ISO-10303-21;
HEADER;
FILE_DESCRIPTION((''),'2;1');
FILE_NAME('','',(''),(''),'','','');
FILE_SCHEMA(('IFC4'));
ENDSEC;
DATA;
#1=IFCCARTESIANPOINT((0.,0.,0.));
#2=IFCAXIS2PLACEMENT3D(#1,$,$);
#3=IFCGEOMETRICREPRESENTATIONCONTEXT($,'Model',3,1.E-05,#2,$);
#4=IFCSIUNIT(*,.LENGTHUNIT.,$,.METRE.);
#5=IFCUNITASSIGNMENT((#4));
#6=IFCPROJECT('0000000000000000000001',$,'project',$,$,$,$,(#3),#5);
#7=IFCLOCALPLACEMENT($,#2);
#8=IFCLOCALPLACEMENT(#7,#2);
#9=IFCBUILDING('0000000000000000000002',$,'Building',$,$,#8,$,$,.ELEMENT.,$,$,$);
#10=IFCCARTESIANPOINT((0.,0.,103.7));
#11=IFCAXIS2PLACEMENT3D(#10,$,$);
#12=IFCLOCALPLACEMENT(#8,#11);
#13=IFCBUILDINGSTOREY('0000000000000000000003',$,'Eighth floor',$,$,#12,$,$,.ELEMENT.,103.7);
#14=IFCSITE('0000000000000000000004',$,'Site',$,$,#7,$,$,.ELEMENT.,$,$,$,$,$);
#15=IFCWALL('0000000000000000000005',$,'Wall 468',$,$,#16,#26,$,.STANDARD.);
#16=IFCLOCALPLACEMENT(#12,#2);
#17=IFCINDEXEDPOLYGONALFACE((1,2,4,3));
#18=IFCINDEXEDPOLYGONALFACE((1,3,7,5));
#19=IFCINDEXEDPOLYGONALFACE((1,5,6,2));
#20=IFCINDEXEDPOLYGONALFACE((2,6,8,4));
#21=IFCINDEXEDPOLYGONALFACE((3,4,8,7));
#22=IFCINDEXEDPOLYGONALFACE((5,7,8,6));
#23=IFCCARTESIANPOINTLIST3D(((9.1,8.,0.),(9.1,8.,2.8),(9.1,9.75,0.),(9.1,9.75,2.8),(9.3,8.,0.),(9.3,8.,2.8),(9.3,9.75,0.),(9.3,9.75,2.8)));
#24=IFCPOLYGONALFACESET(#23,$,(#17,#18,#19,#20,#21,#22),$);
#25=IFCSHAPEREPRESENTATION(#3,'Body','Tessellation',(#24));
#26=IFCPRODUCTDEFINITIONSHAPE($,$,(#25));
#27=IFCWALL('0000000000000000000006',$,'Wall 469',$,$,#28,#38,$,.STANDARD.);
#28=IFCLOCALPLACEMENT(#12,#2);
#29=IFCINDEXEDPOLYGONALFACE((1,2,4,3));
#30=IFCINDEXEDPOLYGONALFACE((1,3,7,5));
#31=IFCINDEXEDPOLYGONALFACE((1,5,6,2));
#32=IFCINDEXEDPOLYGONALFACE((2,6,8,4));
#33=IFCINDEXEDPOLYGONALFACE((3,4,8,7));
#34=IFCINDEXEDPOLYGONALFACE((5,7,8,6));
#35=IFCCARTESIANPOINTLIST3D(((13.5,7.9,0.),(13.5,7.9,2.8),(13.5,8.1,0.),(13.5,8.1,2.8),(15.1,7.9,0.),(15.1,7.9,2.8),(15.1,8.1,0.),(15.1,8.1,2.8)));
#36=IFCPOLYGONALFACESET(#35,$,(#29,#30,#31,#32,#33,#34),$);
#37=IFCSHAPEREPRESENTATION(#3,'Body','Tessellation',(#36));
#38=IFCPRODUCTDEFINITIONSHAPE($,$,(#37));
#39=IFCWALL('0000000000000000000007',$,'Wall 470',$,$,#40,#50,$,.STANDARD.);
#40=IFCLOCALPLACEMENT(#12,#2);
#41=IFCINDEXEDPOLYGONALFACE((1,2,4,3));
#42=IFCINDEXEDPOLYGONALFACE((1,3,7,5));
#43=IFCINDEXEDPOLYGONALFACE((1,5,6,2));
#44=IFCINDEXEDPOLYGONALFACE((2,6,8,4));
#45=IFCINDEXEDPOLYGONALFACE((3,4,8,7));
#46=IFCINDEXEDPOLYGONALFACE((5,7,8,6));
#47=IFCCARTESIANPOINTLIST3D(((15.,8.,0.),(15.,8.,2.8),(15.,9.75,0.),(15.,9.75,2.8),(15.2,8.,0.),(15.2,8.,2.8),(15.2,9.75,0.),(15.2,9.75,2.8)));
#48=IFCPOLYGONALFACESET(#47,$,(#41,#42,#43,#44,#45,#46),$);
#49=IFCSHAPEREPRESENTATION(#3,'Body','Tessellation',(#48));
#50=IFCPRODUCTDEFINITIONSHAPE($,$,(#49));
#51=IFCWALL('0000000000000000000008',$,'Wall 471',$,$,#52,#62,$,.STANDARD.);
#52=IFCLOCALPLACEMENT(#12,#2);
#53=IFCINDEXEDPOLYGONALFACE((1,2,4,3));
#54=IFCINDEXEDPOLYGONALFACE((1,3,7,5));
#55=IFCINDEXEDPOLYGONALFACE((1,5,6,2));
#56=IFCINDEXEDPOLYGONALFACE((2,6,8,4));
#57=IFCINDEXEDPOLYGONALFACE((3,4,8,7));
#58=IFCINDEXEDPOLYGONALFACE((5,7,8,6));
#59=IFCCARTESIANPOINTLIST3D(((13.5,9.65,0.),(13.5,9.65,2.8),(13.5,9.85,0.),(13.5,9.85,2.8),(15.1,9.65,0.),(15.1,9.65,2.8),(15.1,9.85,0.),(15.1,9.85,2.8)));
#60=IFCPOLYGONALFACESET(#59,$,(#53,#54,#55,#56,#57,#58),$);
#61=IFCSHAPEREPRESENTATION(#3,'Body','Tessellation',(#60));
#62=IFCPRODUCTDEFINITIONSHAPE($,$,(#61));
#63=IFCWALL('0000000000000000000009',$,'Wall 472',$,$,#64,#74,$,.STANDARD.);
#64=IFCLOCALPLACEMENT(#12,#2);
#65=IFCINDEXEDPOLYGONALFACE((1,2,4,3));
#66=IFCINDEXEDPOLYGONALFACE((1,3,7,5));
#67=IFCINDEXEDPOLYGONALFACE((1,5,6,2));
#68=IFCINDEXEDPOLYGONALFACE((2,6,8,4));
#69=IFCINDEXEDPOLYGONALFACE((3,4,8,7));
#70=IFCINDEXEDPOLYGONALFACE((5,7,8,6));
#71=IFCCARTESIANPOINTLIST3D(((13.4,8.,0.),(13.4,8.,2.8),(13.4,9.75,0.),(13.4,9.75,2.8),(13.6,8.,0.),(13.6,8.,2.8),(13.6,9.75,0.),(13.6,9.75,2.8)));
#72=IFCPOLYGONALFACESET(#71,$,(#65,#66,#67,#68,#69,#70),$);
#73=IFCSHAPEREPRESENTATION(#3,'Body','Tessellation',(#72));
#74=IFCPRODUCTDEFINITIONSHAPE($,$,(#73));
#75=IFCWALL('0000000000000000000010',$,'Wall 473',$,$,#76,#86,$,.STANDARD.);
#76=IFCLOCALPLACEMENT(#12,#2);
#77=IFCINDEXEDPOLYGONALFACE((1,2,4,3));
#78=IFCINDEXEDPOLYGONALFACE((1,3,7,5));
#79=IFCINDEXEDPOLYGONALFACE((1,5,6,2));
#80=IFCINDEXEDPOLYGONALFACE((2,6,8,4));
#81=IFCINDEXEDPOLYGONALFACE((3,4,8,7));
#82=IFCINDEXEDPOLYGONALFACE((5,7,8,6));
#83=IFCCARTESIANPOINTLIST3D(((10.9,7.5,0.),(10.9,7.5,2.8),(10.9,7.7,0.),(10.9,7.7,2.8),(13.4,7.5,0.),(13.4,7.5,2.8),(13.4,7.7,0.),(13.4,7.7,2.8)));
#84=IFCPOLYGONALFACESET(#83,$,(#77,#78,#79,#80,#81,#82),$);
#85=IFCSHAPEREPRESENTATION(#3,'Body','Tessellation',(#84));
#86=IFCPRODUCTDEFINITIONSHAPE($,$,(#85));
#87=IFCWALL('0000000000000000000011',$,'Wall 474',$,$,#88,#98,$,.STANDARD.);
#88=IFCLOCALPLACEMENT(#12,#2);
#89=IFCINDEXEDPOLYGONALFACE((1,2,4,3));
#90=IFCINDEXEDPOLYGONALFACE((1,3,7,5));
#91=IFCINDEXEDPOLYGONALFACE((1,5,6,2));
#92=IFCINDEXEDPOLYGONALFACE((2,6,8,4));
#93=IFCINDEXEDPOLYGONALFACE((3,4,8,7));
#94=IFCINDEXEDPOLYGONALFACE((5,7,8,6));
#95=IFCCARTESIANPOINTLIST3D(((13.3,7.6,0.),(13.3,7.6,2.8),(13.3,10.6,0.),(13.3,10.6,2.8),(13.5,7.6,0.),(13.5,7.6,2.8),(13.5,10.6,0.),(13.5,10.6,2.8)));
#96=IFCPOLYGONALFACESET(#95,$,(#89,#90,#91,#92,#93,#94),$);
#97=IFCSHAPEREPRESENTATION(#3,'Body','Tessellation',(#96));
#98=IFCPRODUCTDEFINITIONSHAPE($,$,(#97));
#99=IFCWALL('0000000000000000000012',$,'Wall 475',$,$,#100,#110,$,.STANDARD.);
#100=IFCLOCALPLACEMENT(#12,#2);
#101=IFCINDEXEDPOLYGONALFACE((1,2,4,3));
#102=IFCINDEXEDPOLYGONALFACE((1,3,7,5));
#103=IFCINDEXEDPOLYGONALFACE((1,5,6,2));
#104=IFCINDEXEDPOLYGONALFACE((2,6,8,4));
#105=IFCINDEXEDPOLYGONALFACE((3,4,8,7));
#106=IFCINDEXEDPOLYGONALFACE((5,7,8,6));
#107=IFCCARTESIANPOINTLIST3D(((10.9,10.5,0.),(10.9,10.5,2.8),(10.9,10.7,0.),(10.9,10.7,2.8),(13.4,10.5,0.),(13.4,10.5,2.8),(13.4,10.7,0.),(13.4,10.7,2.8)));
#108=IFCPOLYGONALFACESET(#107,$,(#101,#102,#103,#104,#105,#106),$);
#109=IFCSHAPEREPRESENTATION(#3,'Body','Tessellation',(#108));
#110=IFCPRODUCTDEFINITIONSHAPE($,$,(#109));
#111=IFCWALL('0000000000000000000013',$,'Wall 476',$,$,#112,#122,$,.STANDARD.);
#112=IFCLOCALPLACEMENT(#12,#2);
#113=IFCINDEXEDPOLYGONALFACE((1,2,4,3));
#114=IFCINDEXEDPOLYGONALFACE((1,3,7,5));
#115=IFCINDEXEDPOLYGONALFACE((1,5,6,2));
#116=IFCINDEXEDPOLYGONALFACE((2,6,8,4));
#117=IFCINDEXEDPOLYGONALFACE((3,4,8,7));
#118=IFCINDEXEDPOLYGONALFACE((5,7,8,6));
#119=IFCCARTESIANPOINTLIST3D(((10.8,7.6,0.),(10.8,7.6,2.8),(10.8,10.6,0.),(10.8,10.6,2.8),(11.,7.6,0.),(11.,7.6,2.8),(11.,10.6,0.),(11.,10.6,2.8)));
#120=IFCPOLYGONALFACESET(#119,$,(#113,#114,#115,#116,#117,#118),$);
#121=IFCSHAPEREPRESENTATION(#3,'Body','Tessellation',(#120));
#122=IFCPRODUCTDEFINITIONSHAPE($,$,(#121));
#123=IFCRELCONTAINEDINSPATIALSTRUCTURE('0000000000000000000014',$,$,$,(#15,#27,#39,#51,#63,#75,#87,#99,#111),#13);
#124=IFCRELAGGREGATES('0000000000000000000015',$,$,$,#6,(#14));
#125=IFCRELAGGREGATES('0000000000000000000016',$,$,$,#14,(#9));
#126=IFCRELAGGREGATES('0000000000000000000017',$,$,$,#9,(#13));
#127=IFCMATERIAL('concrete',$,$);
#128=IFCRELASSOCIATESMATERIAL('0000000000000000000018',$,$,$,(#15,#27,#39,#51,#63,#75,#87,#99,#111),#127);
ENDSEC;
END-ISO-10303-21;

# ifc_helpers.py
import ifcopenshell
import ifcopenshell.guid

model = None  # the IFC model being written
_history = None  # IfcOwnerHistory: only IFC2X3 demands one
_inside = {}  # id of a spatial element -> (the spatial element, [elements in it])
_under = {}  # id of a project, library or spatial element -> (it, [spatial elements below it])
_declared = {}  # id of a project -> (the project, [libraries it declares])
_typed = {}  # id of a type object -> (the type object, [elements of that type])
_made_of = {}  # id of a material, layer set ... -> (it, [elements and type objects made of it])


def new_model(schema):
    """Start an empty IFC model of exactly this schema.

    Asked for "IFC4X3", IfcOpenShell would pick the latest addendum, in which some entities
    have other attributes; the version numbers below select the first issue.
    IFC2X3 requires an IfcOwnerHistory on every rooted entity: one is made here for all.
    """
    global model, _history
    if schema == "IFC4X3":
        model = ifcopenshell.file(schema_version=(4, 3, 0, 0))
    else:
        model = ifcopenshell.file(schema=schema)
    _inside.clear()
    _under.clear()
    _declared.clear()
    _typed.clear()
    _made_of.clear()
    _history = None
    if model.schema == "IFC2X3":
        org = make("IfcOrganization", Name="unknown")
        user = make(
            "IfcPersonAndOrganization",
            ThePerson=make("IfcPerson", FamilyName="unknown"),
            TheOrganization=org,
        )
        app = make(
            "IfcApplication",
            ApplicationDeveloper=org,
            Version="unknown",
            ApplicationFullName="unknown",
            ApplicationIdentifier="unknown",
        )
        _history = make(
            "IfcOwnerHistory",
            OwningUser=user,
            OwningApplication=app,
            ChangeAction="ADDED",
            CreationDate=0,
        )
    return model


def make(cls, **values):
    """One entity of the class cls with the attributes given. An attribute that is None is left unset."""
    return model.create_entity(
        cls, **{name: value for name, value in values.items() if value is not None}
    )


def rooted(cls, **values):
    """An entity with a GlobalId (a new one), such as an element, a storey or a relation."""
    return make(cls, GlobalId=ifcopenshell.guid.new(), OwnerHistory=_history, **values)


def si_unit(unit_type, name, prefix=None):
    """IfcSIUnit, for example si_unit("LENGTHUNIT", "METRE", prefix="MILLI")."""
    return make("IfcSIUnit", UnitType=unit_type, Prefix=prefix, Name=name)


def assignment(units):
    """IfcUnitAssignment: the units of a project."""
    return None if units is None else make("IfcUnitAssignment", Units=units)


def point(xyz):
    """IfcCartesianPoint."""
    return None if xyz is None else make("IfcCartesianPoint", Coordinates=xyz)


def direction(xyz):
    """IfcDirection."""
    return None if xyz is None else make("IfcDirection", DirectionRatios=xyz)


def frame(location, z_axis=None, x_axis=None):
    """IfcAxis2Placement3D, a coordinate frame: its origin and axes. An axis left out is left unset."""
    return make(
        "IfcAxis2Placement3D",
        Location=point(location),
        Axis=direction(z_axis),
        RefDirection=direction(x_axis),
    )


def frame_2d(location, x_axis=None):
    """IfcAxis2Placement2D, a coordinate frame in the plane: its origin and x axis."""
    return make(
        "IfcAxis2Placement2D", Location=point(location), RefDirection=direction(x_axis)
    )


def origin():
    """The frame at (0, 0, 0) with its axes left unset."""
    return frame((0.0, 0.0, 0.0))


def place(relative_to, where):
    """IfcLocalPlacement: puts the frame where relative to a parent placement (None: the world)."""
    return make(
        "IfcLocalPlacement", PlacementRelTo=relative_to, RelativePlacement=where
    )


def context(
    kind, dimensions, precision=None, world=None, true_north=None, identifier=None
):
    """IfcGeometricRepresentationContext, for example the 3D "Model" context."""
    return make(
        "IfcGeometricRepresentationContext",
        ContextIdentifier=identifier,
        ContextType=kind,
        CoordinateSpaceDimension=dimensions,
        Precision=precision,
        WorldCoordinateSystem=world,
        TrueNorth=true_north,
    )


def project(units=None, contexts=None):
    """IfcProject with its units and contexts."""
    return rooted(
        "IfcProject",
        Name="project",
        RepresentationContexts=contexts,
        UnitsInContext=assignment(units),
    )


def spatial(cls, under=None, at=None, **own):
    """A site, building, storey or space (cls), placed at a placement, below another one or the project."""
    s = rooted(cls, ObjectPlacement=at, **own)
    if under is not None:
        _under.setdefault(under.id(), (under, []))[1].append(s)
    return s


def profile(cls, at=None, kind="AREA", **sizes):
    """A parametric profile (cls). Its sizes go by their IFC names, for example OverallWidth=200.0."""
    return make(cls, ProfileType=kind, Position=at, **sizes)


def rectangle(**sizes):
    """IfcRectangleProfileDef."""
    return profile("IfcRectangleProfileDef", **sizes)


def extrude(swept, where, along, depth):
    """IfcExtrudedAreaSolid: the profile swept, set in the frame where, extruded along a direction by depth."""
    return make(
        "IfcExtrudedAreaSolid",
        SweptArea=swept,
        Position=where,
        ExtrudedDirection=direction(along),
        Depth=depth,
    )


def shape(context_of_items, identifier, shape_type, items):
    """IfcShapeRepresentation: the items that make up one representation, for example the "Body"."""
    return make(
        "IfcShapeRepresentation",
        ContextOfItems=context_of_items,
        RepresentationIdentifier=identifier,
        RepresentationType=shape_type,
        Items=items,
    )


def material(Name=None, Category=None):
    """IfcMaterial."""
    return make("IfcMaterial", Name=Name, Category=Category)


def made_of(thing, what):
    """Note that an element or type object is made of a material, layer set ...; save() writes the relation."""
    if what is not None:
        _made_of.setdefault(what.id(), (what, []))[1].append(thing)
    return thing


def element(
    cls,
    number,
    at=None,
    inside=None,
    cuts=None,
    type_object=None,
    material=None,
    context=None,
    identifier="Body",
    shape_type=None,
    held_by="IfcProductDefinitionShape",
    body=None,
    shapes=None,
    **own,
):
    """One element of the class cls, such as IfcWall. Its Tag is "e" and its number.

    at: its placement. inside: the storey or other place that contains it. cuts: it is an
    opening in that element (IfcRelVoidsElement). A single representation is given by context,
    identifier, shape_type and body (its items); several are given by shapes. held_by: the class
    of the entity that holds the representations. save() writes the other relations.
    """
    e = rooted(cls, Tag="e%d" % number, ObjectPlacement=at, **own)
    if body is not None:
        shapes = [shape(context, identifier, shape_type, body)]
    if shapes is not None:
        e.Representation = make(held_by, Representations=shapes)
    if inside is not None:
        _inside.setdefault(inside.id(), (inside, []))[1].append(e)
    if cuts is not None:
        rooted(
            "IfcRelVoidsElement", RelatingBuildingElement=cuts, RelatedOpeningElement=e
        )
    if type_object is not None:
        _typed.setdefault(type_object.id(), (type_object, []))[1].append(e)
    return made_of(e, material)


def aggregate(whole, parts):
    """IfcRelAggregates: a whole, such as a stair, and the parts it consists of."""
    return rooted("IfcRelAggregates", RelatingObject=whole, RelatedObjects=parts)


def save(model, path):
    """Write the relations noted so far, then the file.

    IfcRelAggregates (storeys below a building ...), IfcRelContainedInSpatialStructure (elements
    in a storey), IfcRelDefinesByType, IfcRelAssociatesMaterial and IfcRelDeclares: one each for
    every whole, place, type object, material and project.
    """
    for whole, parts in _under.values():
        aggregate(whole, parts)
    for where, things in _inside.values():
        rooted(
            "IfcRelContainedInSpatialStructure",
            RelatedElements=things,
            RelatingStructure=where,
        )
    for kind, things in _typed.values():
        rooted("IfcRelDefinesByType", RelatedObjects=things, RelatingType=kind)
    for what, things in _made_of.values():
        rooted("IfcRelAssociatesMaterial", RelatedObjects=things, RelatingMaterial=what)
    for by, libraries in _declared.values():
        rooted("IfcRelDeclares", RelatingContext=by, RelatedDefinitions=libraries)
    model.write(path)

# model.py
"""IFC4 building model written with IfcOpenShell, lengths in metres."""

from ifc_helpers import new_model, si_unit, frame, frame_2d, origin, place, context, project, spatial, rectangle, extrude, material, element, save


model = new_model("IFC4")

# Units and contexts
model_context = context("Model", 3, precision=1e-05, world=origin())
ifc_project = project(units=[si_unit("LENGTHUNIT", "METRE")], contexts=[model_context])

# Site, building, storey
site_placement = place(None, origin())
site = spatial("IfcSite", under=ifc_project, at=site_placement, Name="Site", CompositionType="ELEMENT")
building_placement = place(site_placement, origin())
building = spatial("IfcBuilding", under=site, at=building_placement, Name="Building", CompositionType="ELEMENT")
storey_placement = place(building_placement, frame((0.0, 0.0, 103.7)))
storey = spatial("IfcBuildingStorey", under=building, at=storey_placement, Name="Eighth floor", CompositionType="ELEMENT", Elevation=103.7)

# Shared definitions
ifc_material = material(Name="concrete")

# Walls
wall_1_placement = place(storey_placement, frame((9.2, 9.75, 0.0), z_axis=(0.0, 0.0, 1.0), x_axis=(0.0, -1.0, 0.0)))
element("IfcWall", 1, at=wall_1_placement, inside=storey, material=ifc_material, Name="Wall 468", PredefinedType="STANDARD", context=model_context, shape_type="SweptSolid", body=[
    extrude(rectangle(XDim=1.75, YDim=0.2, at=frame_2d((0.875, 0.0))), origin(), (0.0, 0.0, 1.0), 2.8),
])
wall_2_placement = place(storey_placement, frame((13.5, 8.0, 0.0), z_axis=(0.0, 0.0, 1.0), x_axis=(1.0, 0.0, 0.0)))
element("IfcWall", 2, at=wall_2_placement, inside=storey, material=ifc_material, Name="Wall 469", PredefinedType="STANDARD", context=model_context, shape_type="SweptSolid", body=[
    extrude(rectangle(XDim=1.6, YDim=0.2, at=frame_2d((0.8, 0.0))), origin(), (0.0, 0.0, 1.0), 2.8),
])
wall_3_placement = place(storey_placement, frame((15.1, 8.0, 0.0), z_axis=(0.0, 0.0, 1.0), x_axis=(0.0, 1.0, 0.0)))
element("IfcWall", 3, at=wall_3_placement, inside=storey, material=ifc_material, Name="Wall 470", PredefinedType="STANDARD", context=model_context, shape_type="SweptSolid", body=[
    extrude(rectangle(XDim=1.75, YDim=0.2, at=frame_2d((0.875, 0.0))), origin(), (0.0, 0.0, 1.0), 2.8),
])
wall_4_placement = place(storey_placement, frame((15.1, 9.75, 0.0), z_axis=(0.0, 0.0, 1.0), x_axis=(-1.0, 0.0, 0.0)))
element("IfcWall", 4, at=wall_4_placement, inside=storey, material=ifc_material, Name="Wall 471", PredefinedType="STANDARD", context=model_context, shape_type="SweptSolid", body=[
    extrude(rectangle(XDim=1.6, YDim=0.2, at=frame_2d((0.8, 0.0))), origin(), (0.0, 0.0, 1.0), 2.8),
])
wall_5_placement = place(storey_placement, frame((13.5, 9.75, 0.0), z_axis=(0.0, 0.0, 1.0), x_axis=(0.0, -1.0, 0.0)))
element("IfcWall", 5, at=wall_5_placement, inside=storey, material=ifc_material, Name="Wall 472", PredefinedType="STANDARD", context=model_context, shape_type="SweptSolid", body=[
    extrude(rectangle(XDim=1.75, YDim=0.2, at=frame_2d((0.875, 0.0))), origin(), (0.0, 0.0, 1.0), 2.8),
])
wall_6_placement = place(storey_placement, frame((10.9, 7.6, 0.0), z_axis=(0.0, 0.0, 1.0), x_axis=(1.0, 0.0, 0.0)))
element("IfcWall", 6, at=wall_6_placement, inside=storey, material=ifc_material, Name="Wall 473", PredefinedType="STANDARD", context=model_context, shape_type="SweptSolid", body=[
    extrude(rectangle(XDim=2.5, YDim=0.2, at=frame_2d((1.25, 0.0))), origin(), (0.0, 0.0, 1.0), 2.8),
])
wall_7_placement = place(storey_placement, frame((13.4, 7.6, 0.0), z_axis=(0.0, 0.0, 1.0), x_axis=(0.0, 1.0, 0.0)))
element("IfcWall", 7, at=wall_7_placement, inside=storey, material=ifc_material, Name="Wall 474", PredefinedType="STANDARD", context=model_context, shape_type="SweptSolid", body=[
    extrude(rectangle(XDim=3.0, YDim=0.2, at=frame_2d((1.5, 0.0))), origin(), (0.0, 0.0, 1.0), 2.8),
])
wall_8_placement = place(storey_placement, frame((13.4, 10.6, 0.0), z_axis=(0.0, 0.0, 1.0), x_axis=(-1.0, 0.0, 0.0)))
element("IfcWall", 8, at=wall_8_placement, inside=storey, material=ifc_material, Name="Wall 475", PredefinedType="STANDARD", context=model_context, shape_type="SweptSolid", body=[
    extrude(rectangle(XDim=2.5, YDim=0.2, at=frame_2d((1.25, 0.0))), origin(), (0.0, 0.0, 1.0), 2.8),
])
wall_9_placement = place(storey_placement, frame((10.9, 10.6, 0.0), z_axis=(0.0, 0.0, 1.0), x_axis=(0.0, -1.0, 0.0)))
element("IfcWall", 9, at=wall_9_placement, inside=storey, material=ifc_material, Name="Wall 476", PredefinedType="STANDARD", context=model_context, shape_type="SweptSolid", body=[
    extrude(rectangle(XDim=3.0, YDim=0.2, at=frame_2d((1.5, 0.0))), origin(), (0.0, 0.0, 1.0), 2.8),
])

save(model, "model.ifc")
